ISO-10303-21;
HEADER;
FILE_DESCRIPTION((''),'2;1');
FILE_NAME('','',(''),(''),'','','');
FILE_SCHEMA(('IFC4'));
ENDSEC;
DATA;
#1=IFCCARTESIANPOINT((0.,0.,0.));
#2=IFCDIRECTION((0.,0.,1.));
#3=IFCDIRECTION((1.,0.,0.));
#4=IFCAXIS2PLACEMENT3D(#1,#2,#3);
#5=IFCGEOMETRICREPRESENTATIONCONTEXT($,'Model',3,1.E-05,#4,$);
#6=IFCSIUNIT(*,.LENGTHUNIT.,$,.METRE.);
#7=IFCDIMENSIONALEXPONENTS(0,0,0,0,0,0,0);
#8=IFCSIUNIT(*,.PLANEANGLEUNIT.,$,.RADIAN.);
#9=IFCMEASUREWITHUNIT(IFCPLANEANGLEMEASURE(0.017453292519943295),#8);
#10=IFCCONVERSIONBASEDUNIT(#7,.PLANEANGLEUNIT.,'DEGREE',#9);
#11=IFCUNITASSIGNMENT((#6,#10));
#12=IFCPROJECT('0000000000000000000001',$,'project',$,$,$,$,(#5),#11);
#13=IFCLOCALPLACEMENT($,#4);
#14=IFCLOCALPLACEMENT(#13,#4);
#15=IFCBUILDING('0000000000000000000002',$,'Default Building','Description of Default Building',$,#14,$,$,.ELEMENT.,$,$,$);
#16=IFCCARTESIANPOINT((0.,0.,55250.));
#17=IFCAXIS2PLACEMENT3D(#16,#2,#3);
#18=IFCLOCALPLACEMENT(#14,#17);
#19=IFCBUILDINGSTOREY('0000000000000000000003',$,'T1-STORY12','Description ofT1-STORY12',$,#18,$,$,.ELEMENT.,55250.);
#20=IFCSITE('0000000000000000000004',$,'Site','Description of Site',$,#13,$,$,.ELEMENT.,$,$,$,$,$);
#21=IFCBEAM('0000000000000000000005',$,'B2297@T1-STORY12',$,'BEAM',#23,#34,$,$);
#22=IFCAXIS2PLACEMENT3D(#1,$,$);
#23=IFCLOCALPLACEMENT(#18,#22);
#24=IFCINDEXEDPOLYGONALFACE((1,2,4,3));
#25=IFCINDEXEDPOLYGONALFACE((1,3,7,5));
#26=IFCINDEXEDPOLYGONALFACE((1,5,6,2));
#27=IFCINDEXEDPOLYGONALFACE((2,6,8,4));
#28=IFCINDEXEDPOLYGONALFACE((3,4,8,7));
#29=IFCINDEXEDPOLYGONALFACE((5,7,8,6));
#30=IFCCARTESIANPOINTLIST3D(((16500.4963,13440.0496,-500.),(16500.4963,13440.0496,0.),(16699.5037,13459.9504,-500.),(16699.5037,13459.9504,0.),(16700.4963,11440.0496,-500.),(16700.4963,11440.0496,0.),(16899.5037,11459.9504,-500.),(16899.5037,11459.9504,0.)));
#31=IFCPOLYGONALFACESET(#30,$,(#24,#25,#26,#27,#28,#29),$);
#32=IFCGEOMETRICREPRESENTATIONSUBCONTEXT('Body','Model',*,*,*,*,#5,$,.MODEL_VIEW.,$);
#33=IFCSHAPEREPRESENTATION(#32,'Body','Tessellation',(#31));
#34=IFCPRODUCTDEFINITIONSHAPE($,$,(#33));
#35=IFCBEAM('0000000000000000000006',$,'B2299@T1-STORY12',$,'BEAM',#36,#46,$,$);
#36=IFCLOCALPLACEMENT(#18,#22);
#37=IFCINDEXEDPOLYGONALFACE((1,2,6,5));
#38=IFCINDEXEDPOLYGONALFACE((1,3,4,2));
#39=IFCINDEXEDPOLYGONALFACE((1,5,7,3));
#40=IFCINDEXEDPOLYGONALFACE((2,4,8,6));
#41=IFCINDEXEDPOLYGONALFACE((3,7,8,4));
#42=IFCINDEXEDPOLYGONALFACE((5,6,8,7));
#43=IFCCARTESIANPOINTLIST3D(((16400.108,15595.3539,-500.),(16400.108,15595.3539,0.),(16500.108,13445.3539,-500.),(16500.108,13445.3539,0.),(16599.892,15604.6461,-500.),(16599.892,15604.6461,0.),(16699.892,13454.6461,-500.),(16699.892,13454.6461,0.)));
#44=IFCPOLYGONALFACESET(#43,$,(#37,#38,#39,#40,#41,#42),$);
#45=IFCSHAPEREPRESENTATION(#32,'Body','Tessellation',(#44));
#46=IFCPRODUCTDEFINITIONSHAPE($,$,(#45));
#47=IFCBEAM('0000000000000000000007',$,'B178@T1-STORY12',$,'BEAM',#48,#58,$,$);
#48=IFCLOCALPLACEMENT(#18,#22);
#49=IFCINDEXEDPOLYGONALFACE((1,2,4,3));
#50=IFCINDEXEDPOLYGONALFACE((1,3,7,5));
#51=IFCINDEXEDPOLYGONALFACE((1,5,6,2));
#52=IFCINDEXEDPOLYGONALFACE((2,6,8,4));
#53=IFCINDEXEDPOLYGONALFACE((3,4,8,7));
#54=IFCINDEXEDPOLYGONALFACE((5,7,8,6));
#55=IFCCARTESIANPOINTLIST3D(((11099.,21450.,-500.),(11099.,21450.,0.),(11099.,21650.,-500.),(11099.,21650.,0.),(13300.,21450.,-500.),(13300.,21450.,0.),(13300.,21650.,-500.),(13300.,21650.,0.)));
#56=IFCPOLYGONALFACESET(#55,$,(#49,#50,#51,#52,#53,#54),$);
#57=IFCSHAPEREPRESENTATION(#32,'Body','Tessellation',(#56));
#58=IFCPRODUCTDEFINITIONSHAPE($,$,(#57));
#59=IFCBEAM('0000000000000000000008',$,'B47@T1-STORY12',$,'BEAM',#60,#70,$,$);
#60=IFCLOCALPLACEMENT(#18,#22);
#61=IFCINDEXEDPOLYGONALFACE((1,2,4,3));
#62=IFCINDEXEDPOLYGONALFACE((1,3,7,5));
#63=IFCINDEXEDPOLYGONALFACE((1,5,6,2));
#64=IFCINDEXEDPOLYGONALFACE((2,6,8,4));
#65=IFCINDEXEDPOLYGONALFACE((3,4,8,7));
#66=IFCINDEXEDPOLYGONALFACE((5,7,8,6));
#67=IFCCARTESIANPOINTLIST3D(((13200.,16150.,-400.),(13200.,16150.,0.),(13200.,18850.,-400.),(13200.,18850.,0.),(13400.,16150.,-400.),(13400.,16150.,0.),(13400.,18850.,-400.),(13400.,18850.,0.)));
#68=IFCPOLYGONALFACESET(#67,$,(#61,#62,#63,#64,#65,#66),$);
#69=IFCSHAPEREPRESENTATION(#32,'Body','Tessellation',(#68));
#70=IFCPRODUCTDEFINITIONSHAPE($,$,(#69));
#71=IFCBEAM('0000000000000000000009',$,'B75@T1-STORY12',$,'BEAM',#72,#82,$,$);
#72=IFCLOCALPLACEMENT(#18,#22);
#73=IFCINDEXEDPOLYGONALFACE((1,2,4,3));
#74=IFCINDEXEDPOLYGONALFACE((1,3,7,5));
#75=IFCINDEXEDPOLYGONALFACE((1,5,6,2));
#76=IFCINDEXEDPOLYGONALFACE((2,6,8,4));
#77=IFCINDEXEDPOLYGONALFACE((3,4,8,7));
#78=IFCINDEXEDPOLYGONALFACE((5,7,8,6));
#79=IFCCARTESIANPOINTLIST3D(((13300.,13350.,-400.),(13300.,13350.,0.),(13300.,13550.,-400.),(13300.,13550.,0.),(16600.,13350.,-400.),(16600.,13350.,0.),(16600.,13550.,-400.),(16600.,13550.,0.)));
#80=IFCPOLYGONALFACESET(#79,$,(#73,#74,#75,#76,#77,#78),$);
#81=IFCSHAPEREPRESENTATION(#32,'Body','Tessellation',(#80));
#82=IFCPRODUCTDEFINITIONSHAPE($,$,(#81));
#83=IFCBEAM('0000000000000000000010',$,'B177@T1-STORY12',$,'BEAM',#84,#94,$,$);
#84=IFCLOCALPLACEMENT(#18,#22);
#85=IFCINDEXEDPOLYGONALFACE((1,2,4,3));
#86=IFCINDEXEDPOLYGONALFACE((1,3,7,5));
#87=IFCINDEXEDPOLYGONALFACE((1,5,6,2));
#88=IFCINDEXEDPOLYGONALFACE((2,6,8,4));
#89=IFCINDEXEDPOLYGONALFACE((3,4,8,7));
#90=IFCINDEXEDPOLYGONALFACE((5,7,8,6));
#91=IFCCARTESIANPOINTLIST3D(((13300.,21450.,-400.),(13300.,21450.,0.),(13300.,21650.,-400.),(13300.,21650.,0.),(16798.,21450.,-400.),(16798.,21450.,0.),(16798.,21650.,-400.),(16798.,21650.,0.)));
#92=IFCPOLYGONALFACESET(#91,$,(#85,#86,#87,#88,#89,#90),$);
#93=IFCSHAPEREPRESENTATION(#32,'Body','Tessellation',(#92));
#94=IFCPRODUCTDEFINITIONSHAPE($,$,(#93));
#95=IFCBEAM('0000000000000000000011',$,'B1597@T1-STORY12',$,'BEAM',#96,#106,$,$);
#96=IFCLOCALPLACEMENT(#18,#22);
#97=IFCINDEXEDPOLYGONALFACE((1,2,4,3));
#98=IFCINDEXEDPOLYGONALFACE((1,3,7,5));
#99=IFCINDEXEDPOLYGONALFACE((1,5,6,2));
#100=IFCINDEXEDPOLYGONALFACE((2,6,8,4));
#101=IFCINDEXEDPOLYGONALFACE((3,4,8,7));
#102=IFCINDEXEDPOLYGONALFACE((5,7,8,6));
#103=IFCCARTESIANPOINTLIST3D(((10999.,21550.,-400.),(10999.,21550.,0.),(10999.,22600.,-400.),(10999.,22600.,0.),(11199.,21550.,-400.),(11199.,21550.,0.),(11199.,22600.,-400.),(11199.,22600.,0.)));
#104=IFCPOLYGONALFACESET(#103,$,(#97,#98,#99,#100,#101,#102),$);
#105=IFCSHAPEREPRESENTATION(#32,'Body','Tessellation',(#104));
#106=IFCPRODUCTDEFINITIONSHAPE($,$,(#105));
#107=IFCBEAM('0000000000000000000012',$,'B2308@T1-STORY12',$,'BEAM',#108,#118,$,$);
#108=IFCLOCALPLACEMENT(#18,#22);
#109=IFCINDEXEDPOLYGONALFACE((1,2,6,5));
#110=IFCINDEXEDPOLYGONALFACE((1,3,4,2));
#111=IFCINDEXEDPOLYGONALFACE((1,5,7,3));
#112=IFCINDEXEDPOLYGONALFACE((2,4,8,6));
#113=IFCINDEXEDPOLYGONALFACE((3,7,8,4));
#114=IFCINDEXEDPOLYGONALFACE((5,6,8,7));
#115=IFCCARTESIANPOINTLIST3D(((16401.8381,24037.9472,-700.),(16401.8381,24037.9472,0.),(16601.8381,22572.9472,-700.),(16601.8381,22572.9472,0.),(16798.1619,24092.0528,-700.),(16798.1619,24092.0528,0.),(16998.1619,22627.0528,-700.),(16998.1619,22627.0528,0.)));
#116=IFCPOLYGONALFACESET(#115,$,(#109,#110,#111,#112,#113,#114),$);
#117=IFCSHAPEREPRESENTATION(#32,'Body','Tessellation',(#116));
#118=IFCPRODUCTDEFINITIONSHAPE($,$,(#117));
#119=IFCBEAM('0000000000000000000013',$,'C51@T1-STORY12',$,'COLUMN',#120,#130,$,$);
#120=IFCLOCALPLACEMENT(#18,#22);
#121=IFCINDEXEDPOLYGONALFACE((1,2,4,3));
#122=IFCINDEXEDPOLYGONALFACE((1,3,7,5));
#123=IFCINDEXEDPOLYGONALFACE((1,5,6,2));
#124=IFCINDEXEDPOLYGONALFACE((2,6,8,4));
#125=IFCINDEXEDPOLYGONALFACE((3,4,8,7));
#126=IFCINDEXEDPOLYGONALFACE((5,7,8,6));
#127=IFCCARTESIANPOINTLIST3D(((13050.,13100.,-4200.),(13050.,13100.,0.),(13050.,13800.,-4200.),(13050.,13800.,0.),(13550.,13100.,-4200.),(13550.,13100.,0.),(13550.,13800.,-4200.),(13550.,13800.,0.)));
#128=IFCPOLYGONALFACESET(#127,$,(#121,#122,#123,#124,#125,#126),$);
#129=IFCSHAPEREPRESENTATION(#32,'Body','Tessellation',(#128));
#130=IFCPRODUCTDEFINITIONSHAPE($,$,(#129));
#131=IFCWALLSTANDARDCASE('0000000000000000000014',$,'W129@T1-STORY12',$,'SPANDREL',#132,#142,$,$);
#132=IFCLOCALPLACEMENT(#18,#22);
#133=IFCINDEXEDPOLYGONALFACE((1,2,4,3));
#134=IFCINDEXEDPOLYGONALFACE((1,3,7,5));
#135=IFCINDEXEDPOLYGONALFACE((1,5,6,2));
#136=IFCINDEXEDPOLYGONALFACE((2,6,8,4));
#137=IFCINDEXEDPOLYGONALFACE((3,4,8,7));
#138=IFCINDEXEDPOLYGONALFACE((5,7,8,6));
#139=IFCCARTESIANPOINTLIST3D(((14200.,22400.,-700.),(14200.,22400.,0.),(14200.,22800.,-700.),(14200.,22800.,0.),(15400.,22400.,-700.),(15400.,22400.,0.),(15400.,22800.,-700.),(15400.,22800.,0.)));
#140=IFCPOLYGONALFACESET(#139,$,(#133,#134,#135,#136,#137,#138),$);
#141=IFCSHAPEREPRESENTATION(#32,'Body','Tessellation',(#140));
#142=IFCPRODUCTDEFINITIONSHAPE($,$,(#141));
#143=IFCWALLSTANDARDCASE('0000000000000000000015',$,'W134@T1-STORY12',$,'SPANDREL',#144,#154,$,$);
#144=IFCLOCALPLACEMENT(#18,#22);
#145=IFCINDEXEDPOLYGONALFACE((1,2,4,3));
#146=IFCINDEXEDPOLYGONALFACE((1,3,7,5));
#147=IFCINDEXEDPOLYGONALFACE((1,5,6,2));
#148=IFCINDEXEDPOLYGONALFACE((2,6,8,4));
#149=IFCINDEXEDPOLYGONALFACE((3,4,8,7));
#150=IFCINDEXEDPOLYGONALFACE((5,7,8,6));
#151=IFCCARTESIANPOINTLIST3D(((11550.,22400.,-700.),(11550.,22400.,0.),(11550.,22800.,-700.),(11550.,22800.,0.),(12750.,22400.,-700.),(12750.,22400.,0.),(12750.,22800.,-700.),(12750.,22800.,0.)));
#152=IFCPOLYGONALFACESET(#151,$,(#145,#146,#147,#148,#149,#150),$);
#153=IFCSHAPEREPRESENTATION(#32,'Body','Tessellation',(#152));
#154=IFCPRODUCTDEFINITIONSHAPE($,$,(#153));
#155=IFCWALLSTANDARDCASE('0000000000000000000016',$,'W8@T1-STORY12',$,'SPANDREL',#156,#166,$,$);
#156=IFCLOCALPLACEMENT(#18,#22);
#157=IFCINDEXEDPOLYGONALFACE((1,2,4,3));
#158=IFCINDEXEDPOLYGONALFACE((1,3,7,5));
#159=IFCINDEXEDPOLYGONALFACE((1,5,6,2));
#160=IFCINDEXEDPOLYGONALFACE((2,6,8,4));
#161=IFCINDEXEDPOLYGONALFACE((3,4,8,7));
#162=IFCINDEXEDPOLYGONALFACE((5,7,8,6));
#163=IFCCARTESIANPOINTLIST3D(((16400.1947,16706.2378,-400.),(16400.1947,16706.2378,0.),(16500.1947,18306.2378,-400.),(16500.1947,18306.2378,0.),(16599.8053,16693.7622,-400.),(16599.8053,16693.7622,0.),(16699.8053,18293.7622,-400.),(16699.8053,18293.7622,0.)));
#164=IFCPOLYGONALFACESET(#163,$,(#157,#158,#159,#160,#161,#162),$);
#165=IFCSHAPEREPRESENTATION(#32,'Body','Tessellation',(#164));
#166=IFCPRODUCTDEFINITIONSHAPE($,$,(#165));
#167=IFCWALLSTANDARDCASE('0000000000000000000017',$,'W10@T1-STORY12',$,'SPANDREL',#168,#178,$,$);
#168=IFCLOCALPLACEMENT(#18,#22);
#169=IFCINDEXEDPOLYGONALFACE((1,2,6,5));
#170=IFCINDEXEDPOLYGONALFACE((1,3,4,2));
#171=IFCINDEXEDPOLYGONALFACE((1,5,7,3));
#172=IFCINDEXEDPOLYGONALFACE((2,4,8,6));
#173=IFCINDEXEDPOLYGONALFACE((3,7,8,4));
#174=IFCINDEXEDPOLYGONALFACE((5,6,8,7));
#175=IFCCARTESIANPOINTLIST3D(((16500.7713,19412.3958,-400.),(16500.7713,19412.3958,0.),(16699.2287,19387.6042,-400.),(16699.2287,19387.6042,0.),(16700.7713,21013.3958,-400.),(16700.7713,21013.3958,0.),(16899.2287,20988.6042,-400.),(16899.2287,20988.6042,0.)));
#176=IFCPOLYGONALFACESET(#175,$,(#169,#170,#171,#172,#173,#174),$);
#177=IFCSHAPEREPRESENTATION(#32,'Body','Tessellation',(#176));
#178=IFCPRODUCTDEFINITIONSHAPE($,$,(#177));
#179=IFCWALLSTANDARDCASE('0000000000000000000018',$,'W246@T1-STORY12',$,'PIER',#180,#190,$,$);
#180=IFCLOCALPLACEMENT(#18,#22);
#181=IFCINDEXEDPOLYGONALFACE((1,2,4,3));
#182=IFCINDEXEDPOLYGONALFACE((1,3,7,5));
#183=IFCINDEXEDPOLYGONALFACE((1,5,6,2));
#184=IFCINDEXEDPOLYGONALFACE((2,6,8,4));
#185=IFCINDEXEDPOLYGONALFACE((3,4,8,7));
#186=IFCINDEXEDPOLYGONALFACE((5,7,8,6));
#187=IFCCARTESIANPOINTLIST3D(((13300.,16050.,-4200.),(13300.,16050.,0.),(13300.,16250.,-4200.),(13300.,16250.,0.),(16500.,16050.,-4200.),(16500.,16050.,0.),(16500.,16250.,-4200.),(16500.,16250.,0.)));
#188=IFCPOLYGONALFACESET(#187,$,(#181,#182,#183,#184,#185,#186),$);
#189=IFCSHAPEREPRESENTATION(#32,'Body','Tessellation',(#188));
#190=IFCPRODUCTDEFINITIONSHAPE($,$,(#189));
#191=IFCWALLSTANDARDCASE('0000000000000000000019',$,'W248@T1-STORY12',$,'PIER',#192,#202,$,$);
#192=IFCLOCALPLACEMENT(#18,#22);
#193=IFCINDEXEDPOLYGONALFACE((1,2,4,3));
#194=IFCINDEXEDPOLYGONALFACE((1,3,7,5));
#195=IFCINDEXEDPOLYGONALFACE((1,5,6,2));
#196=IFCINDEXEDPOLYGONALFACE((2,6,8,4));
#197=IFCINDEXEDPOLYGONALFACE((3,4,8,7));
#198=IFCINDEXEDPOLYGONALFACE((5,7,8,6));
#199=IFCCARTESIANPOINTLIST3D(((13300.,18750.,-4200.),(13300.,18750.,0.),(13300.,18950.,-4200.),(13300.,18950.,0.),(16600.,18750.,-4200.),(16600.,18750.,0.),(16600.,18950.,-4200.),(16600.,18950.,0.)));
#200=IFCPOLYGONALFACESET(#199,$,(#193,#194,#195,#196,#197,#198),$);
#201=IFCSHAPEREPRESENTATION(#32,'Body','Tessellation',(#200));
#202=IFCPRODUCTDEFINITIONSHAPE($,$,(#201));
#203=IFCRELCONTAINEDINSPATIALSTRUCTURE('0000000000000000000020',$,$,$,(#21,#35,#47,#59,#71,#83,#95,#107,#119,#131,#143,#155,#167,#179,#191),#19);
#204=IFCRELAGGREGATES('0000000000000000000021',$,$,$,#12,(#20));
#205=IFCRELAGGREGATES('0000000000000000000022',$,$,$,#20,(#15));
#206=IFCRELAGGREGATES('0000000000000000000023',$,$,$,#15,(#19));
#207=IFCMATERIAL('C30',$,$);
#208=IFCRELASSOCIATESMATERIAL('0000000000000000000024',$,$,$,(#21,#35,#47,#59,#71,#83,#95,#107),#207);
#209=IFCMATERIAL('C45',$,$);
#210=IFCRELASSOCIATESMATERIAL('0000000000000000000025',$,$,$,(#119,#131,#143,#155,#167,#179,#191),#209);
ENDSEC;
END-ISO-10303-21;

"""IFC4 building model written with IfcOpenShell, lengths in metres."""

from ifc_helpers import new_model, entity, si_unit, converted_unit, frame, origin_with_axes, place, context, subcontext, project, spatial, indexed_curve, rectangle, outline, extrude, material, element, save


model = new_model("IFC4")

# Units and contexts
model_context = context("Model", 3, precision=1e-05, world=origin_with_axes())
body_context = subcontext(model_context, "Body", "Model", "MODEL_VIEW")
ifc_project = project(units=[si_unit("LENGTHUNIT", "METRE"), converted_unit("PLANEANGLEUNIT", "DEGREE", entity("IfcPlaneAngleMeasure", 0.017453292519943295), si_unit("PLANEANGLEUNIT", "RADIAN"), dimensions=[0, 0, 0, 0, 0, 0, 0])], contexts=[model_context])

# Site, building, storey
site_placement = place(None, origin_with_axes())
site = spatial("IfcSite", under=ifc_project, at=site_placement, Name="Site", Description="Description of Site", CompositionType="ELEMENT")
building_placement = place(site_placement, origin_with_axes())
building = spatial("IfcBuilding", under=site, at=building_placement, Name="Default Building", Description="Description of Default Building", CompositionType="ELEMENT")
storey_placement = place(building_placement, frame((0.0, 0.0, 55250.0), z_axis=(0.0, 0.0, 1.0), x_axis=(1.0, 0.0, 0.0)))
storey = spatial("IfcBuildingStorey", under=building, at=storey_placement, Name="T1-STORY12", Description="Description ofT1-STORY12", CompositionType="ELEMENT", Elevation=55250.0)

# Beams
ifc_material_1 = material(Name="C30")
beam_1_placement = place(storey_placement, frame((16600.0, 13450.0, -250.0), z_axis=(0.099504, -0.995037, 0.0), x_axis=(0.995037, 0.099504, 0.0)))
element("IfcBeam", 1, at=beam_1_placement, inside=storey, material=ifc_material_1, Name="B2297@T1-STORY12", ObjectType="BEAM", context=body_context, shape_type="SweptSolid", body=[
    extrude(rectangle(XDim=200.0, YDim=500.0), origin_with_axes(), (0.0, 0.0, 1.0), 2009.9751),
])
beam_2_placement = place(storey_placement, frame((16500.0, 15600.0, -250.0), z_axis=(0.046461, -0.99892, 0.0), x_axis=(0.99892, 0.046461, 0.0)))
element("IfcBeam", 2, at=beam_2_placement, inside=storey, material=ifc_material_1, Name="B2299@T1-STORY12", ObjectType="BEAM", context=body_context, shape_type="SweptSolid", body=[
    extrude(rectangle(XDim=200.0, YDim=500.0), origin_with_axes(), (0.0, 0.0, 1.0), 2152.3243),
])
beam_3_placement = place(storey_placement, frame((11099.0, 21550.0, -250.0), z_axis=(1.0, 0.0, 0.0), x_axis=(0.0, 1.0, 0.0)))
element("IfcBeam", 3, at=beam_3_placement, inside=storey, material=ifc_material_1, Name="B178@T1-STORY12", ObjectType="BEAM", context=body_context, shape_type="SweptSolid", body=[
    extrude(rectangle(XDim=200.0, YDim=500.0), origin_with_axes(), (0.0, 0.0, 1.0), 2201.0),
])
beam_4_placement = place(storey_placement, frame((13300.0, 16150.0, -200.0), z_axis=(0.0, 1.0, 0.0), x_axis=(-1.0, 0.0, 0.0)))
element("IfcBeam", 4, at=beam_4_placement, inside=storey, material=ifc_material_1, Name="B47@T1-STORY12", ObjectType="BEAM", context=body_context, shape_type="SweptSolid", body=[
    extrude(rectangle(XDim=200.0, YDim=400.0), origin_with_axes(), (0.0, 0.0, 1.0), 2700.0),
])
beam_5_placement = place(storey_placement, frame((13300.0, 13450.0, -200.0), z_axis=(1.0, 0.0, 0.0), x_axis=(0.0, 1.0, 0.0)))
element("IfcBeam", 5, at=beam_5_placement, inside=storey, material=ifc_material_1, Name="B75@T1-STORY12", ObjectType="BEAM", context=body_context, shape_type="SweptSolid", body=[
    extrude(rectangle(XDim=200.0, YDim=400.0), origin_with_axes(), (0.0, 0.0, 1.0), 3300.0),
])
beam_6_placement = place(storey_placement, frame((13300.0, 21550.0, -200.0), z_axis=(1.0, 0.0, 0.0), x_axis=(0.0, 1.0, 0.0)))
element("IfcBeam", 6, at=beam_6_placement, inside=storey, material=ifc_material_1, Name="B177@T1-STORY12", ObjectType="BEAM", context=body_context, shape_type="SweptSolid", body=[
    extrude(rectangle(XDim=200.0, YDim=400.0), origin_with_axes(), (0.0, 0.0, 1.0), 3498.0),
])
beam_7_placement = place(storey_placement, frame((11099.0, 21550.0, -200.0), z_axis=(0.0, 1.0, 0.0), x_axis=(-1.0, 0.0, 0.0)))
element("IfcBeam", 7, at=beam_7_placement, inside=storey, material=ifc_material_1, Name="B1597@T1-STORY12", ObjectType="BEAM", context=body_context, shape_type="SweptSolid", body=[
    extrude(rectangle(XDim=200.0, YDim=400.0), origin_with_axes(), (0.0, 0.0, 1.0), 1050.0),
])
beam_8_placement = place(storey_placement, frame((16600.0, 24065.0, -350.0), z_axis=(0.135264, -0.99081, 0.0), x_axis=(0.99081, 0.135264, 0.0)))
element("IfcBeam", 8, at=beam_8_placement, inside=storey, material=ifc_material_1, Name="B2308@T1-STORY12", ObjectType="BEAM", context=body_context, shape_type="SweptSolid", body=[
    extrude(rectangle(XDim=400.0, YDim=700.0), origin_with_axes(), (0.0, 0.0, 1.0), 1478.5889),
])
ifc_material_2 = material(Name="C45")
beam_9_placement = place(storey_placement, frame((13300.0, 13450.0, -4200.0), z_axis=(0.0, 0.0, 1.0), x_axis=(-1.0, 0.0, 0.0)))
element("IfcBeam", 9, at=beam_9_placement, inside=storey, material=ifc_material_2, Name="C51@T1-STORY12", ObjectType="COLUMN", context=body_context, shape_type="SweptSolid", body=[
    extrude(rectangle(XDim=500.0, YDim=700.0), origin_with_axes(), (0.0, 0.0, 1.0), 4200.0),
])

# Walls
for number, where, z_axis, x_axis, name in (
    (10, (14200.0, 22600.0, -700.0), (0.0, 0.0, 1.0), (1.0, 0.0, 0.0), "W129@T1-STORY12"),
    (11, (11550.0, 22600.0, -700.0), (0.0, 0.0, 1.0), (1.0, 0.0, 0.0), "W134@T1-STORY12"),
):
    element("IfcWallStandardCase", number, at=place(storey_placement, frame(where, z_axis=z_axis, x_axis=x_axis)), inside=storey, material=ifc_material_2, Name=name, ObjectType="SPANDREL", context=body_context, shape_type="SweptSolid", body=[
        extrude(outline(indexed_curve([(0.0, -200.0), (0.0, 200.0), (1200.0, 200.0), (1200.0, -200.0), (0.0, -200.0)], self_intersect=False)), origin_with_axes(), (0.0, 0.0, 1.0), 700.0),
    ])
wall_1_placement = place(storey_placement, frame((16500.0, 16700.0, -400.0), z_axis=(0.0, 0.0, 1.0), x_axis=(0.062378, 0.998053, 0.0)))
element("IfcWallStandardCase", 12, at=wall_1_placement, inside=storey, material=ifc_material_2, Name="W8@T1-STORY12", ObjectType="SPANDREL", context=body_context, shape_type="SweptSolid", body=[
    extrude(outline(indexed_curve([(0.0, -100.0), (0.0, 100.0), (1603.122, 100.0), (1603.122, -100.0), (0.0, -100.0)], self_intersect=False)), origin_with_axes(), (0.0, 0.0, 1.0), 400.0),
])
wall_2_placement = place(storey_placement, frame((16600.0, 19400.0, -400.0), z_axis=(0.0, 0.0, 1.0), x_axis=(0.123958, 0.992287, 0.0)))
element("IfcWallStandardCase", 13, at=wall_2_placement, inside=storey, material=ifc_material_2, Name="W10@T1-STORY12", ObjectType="SPANDREL", context=body_context, shape_type="SweptSolid", body=[
    extrude(outline(indexed_curve([(0.0, -100.0), (0.0, 100.0), (1613.4438, 100.0), (1613.4438, -100.0), (0.0, -100.0)], self_intersect=False)), origin_with_axes(), (0.0, 0.0, 1.0), 400.0),
])
wall_3_placement = place(storey_placement, frame((13300.0, 16150.0, -4200.0), z_axis=(0.0, 0.0, 1.0), x_axis=(1.0, 0.0, 0.0)))
element("IfcWallStandardCase", 14, at=wall_3_placement, inside=storey, material=ifc_material_2, Name="W246@T1-STORY12", ObjectType="PIER", context=body_context, shape_type="SweptSolid", body=[
    extrude(outline(indexed_curve([(0.0, -100.0), (0.0, 100.0), (3200.0, 100.0), (3200.0, -100.0), (0.0, -100.0)], self_intersect=False)), origin_with_axes(), (0.0, 0.0, 1.0), 4200.0),
])
wall_4_placement = place(storey_placement, frame((13300.0, 18850.0, -4200.0), z_axis=(0.0, 0.0, 1.0), x_axis=(1.0, 0.0, 0.0)))
element("IfcWallStandardCase", 15, at=wall_4_placement, inside=storey, material=ifc_material_2, Name="W248@T1-STORY12", ObjectType="PIER", context=body_context, shape_type="SweptSolid", body=[
    extrude(outline(indexed_curve([(0.0, -100.0), (0.0, 100.0), (3300.0, 100.0), (3300.0, -100.0), (0.0, -100.0)], self_intersect=False)), origin_with_axes(), (0.0, 0.0, 1.0), 4200.0),
])

save(model, "model.ifc")
